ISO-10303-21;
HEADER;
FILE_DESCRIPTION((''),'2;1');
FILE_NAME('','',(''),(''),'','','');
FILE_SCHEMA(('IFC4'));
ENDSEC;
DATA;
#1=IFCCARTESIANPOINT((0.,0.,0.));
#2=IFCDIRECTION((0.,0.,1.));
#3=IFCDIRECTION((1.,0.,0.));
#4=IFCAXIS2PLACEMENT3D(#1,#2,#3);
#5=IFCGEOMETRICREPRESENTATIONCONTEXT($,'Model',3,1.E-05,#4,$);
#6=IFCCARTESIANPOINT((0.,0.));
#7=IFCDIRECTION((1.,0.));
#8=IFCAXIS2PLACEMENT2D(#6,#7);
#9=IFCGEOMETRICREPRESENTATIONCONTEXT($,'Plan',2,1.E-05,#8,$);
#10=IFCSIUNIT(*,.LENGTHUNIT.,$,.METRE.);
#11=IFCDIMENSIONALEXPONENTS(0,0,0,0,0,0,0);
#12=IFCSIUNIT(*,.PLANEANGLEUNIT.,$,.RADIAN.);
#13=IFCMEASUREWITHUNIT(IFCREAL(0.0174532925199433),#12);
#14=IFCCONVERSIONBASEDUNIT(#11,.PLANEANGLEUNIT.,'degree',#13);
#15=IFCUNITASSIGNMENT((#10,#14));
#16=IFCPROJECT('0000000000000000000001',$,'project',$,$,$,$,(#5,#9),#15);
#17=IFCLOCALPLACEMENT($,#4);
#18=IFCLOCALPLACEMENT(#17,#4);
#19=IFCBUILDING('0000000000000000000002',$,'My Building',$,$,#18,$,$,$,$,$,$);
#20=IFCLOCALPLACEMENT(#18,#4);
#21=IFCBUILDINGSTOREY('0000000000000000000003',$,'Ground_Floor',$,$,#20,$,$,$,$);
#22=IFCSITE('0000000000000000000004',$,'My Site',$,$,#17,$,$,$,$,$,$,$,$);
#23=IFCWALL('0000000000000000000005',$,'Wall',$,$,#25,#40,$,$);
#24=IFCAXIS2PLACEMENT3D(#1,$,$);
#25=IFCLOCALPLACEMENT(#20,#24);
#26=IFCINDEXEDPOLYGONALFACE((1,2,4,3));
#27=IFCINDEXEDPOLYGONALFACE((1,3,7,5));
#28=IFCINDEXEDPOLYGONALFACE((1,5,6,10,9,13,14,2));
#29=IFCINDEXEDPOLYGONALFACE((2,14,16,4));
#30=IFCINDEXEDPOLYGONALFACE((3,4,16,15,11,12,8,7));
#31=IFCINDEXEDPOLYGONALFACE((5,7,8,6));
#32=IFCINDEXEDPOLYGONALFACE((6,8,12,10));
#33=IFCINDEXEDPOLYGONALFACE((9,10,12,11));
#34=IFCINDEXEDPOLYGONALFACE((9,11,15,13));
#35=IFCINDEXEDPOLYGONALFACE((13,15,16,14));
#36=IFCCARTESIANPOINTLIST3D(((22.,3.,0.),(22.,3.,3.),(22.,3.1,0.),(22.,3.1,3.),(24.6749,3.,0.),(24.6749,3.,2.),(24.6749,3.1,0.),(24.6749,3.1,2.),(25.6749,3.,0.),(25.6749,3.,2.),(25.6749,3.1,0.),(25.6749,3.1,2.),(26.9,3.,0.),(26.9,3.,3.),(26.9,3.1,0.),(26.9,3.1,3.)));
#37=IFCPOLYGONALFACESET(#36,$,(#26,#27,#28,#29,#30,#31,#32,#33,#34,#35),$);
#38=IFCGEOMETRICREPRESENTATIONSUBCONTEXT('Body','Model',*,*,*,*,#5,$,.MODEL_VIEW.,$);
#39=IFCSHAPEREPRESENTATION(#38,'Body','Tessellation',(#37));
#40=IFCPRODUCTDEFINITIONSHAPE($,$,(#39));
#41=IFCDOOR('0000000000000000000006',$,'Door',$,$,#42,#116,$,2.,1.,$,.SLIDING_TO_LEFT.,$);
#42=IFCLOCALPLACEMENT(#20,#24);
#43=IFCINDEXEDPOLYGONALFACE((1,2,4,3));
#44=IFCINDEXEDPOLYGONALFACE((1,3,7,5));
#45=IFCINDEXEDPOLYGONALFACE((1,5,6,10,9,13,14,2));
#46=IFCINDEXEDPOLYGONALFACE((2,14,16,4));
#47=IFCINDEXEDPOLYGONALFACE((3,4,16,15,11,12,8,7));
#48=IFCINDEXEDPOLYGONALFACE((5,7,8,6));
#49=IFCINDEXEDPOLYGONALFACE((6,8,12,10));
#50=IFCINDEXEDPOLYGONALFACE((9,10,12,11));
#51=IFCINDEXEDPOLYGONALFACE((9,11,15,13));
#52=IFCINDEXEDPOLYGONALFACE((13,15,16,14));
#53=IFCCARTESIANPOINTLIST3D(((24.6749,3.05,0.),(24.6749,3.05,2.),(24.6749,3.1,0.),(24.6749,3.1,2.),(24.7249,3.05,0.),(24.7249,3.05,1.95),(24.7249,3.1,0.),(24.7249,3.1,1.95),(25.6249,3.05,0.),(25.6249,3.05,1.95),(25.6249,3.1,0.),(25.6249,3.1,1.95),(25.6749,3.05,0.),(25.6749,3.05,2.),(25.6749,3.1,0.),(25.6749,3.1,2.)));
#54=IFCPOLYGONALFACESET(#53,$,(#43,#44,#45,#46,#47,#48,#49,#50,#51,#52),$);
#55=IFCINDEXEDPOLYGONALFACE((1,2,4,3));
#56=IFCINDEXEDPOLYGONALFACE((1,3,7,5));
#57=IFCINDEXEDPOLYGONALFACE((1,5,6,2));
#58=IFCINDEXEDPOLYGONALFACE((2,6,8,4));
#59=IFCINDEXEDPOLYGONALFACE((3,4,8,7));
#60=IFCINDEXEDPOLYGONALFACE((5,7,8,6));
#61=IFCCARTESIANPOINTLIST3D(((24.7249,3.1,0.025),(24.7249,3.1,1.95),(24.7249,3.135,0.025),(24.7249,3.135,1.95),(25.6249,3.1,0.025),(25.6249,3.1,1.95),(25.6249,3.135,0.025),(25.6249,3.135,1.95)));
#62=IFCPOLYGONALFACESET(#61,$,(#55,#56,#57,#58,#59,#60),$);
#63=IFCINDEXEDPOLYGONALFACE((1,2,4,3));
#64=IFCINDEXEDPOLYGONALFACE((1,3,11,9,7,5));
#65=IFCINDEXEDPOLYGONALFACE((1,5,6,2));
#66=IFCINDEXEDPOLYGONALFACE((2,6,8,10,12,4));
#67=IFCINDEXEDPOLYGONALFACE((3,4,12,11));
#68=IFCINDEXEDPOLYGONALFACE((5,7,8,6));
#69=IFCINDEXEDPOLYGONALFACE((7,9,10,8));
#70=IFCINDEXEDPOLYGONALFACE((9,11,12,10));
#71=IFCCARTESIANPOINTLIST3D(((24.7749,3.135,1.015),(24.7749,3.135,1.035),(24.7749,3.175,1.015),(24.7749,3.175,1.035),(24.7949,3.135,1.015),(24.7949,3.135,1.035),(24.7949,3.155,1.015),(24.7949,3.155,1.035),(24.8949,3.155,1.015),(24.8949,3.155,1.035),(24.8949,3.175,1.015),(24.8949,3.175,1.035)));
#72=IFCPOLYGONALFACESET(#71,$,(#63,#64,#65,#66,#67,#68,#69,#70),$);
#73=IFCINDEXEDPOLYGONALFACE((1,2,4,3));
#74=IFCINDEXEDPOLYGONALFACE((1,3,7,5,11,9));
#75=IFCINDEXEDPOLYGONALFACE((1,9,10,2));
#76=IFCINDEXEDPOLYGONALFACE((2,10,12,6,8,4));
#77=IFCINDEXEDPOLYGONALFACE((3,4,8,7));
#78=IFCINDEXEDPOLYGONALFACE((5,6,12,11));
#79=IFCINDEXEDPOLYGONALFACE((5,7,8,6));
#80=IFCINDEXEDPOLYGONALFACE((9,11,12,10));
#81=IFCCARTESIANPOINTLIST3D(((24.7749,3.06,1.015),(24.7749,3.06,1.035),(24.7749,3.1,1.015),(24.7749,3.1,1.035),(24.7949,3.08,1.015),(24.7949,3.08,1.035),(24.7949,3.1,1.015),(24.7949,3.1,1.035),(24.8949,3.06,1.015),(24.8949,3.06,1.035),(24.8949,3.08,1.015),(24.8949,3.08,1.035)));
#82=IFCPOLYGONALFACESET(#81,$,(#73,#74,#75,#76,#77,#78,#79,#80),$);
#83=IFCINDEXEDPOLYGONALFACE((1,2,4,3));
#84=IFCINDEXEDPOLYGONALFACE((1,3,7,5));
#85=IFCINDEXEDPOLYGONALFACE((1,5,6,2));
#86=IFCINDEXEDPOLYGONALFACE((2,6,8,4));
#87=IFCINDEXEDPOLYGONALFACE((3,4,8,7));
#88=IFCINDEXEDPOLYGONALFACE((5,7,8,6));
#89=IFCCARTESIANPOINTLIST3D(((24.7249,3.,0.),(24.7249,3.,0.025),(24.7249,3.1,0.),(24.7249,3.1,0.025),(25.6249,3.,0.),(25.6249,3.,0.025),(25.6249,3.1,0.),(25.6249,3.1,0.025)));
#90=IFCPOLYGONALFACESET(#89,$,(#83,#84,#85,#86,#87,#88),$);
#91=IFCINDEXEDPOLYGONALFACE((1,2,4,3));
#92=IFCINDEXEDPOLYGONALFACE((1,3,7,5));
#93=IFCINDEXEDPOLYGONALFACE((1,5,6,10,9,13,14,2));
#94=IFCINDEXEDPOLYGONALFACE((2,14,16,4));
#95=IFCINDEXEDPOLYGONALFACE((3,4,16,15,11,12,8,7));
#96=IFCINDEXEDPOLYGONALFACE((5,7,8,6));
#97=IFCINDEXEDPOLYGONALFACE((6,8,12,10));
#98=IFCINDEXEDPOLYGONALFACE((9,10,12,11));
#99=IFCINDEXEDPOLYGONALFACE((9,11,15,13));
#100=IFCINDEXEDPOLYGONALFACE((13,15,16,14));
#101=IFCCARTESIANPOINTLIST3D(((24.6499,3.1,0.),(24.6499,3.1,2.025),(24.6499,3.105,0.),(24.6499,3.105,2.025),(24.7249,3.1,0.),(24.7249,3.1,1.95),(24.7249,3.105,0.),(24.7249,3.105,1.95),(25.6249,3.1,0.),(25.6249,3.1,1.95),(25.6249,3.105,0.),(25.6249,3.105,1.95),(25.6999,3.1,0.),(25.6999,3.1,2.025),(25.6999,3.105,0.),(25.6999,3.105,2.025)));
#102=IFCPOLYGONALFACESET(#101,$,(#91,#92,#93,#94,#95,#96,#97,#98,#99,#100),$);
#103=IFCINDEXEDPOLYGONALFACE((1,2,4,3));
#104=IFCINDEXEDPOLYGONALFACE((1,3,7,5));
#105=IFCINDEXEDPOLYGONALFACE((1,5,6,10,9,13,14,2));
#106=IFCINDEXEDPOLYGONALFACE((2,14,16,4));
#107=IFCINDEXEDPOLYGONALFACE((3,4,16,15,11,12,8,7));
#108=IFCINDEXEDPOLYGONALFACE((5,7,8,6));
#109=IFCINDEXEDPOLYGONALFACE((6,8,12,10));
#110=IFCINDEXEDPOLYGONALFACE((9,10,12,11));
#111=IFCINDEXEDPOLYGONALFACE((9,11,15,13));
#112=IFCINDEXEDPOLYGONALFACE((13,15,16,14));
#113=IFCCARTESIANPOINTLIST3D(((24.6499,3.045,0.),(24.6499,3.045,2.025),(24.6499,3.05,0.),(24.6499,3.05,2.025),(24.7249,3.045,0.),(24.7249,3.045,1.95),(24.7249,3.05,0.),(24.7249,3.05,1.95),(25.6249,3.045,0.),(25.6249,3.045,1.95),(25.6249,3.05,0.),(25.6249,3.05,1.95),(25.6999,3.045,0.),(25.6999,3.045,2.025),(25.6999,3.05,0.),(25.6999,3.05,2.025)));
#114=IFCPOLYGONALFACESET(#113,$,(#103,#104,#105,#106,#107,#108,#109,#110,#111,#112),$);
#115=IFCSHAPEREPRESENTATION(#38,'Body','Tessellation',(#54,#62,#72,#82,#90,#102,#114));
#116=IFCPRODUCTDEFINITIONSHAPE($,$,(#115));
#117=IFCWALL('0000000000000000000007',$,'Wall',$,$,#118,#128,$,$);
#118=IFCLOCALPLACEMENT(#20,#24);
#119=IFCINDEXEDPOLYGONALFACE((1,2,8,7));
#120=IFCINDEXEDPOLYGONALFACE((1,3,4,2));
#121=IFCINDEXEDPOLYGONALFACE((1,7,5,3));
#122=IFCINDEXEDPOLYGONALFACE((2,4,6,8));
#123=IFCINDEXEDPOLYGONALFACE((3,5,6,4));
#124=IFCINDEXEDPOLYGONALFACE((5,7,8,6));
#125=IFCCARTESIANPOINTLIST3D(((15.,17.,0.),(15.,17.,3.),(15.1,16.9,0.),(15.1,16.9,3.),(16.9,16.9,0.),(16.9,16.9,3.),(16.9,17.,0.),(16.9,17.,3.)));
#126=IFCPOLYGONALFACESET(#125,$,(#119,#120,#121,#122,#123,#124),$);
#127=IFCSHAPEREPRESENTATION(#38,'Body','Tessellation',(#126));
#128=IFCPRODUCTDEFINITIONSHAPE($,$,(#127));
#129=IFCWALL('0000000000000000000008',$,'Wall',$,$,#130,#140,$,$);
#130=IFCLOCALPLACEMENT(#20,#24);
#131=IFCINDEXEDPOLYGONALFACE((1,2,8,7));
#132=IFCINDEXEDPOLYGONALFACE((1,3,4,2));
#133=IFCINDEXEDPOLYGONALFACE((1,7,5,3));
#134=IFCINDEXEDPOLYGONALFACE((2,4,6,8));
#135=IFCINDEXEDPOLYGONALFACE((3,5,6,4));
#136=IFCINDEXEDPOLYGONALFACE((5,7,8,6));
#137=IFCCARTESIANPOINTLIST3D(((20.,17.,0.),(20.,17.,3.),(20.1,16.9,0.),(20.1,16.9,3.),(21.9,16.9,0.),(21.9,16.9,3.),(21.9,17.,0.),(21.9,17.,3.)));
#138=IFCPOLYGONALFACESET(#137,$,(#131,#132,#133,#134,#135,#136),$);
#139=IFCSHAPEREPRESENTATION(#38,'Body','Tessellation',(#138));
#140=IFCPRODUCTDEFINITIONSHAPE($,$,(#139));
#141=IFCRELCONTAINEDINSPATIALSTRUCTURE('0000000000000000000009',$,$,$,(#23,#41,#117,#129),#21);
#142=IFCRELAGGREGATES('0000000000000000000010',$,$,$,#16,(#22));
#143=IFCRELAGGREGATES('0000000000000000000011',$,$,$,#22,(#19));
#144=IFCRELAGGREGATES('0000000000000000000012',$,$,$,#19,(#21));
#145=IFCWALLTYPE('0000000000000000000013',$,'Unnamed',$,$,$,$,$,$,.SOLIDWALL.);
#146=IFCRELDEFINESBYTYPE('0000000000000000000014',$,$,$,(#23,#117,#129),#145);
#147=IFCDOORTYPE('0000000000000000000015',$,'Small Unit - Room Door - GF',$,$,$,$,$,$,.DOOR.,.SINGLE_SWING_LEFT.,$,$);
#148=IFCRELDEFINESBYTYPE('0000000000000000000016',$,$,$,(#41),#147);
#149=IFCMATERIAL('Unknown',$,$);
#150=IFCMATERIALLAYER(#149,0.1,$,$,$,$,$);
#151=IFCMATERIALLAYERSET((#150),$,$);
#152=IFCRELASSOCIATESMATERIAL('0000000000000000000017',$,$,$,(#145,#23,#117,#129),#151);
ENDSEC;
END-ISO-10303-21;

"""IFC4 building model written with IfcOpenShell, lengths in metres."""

from ifc_helpers import new_model, entity, si_unit, converted_unit, frame, origin_with_axes, origin_2d_with_axis, place, context, subcontext, project, spatial, line, indexed_curve, outline, extrude, shape, source, transform, mapped, material, layer, layer_set, layer_usage, type_object, type_shapes, element, fill, save


model = new_model("IFC4")

# Units and contexts
model_context = context("Model", 3, precision=1e-05, world=origin_with_axes())
plan_context = context("Plan", 2, precision=1e-05, world=origin_2d_with_axis())
body_context_1 = subcontext(model_context, "Body", "Model", "MODEL_VIEW")
body_context_2 = subcontext(plan_context, "Body", "Plan", "PLAN_VIEW")
ifc_project = project(units=[si_unit("LENGTHUNIT", "METRE"), converted_unit("PLANEANGLEUNIT", "degree", entity("IfcReal", 0.0174532925199433), si_unit("PLANEANGLEUNIT", "RADIAN"), dimensions=[0, 0, 0, 0, 0, 0, 0])], contexts=[model_context, plan_context])

# Site, building, storey
site_placement = place(None, origin_with_axes())
site = spatial("IfcSite", under=ifc_project, at=site_placement, Name="My Site")
building_placement = place(site_placement, origin_with_axes())
building = spatial("IfcBuilding", under=site, at=building_placement, Name="My Building")
storey_placement = place(building_placement, origin_with_axes())
storey = spatial("IfcBuildingStorey", under=building, at=storey_placement, Name="Ground_Floor")

# Shared definitions
ifc_material = material(Name="Unknown")
ifc_layer = layer(ifc_material, 0.1)
ifc_layer_set = layer_set([ifc_layer])
wall_type = type_object("IfcWallType", Name="Unnamed", PredefinedType="SOLIDWALL", material=ifc_layer_set)

# Shared definitions
shared_shape_1 = source(origin_with_axes(), body_context_1, "Body", "SweptSolid", [
    extrude(outline(indexed_curve([(0.0, 0.0), (1.0, 0.0), (1.0, 2.0), (0.0, 2.0)], segments=[line(1, 2, 3, 4, 1)])), frame((0.0, -0.6, 0.0), z_axis=(0.0, -1.0, 0.0), x_axis=(1.0, 0.0, 0.0)), (0.0, 0.0, -1.0), 1.2),
])
door_type_1 = type_object("IfcDoorType", Name="Small Unit - Room Door - GF", OperationType="SINGLE_SWING_LEFT", PredefinedType="DOOR")
shared_shape_2 = source(origin_with_axes(), body_context_1, "Body", "SweptSolid", [
    extrude(outline(indexed_curve([(0.0, 0.0), (0.0, 2.0), (1.0, 2.0), (1.0, 0.0), (0.95, 0.0), (0.95, 1.95), (0.05, 1.95), (0.05, 0.0)], segments=[line(1, 2, 3, 4, 5, 6, 7, 8, 1)])), frame((0.0, 0.0, 0.0), z_axis=(0.0, -1.0, 0.0), x_axis=(1.0, 0.0, 0.0)), (0.0, 0.0, -1.0), 0.05),
    extrude(outline(indexed_curve([(0.0, 0.0), (0.9, 0.0), (0.9, 0.035), (0.0, 0.035)], segments=[line(1, 2, 3, 4, 1)])), frame((0.05, -0.035, 0.025), z_axis=(0.0, 0.0, 1.0), x_axis=(1.0, 0.0, 0.0)), (0.0, 0.0, 1.0), 1.925),
    extrude(outline(indexed_curve([(0.0, 0.0), (0.0, -0.04), (-0.12, -0.04), (-0.12, -0.02), (-0.02, -0.02), (-0.02, 0.0)], segments=[line(1, 2, 3, 4, 5, 6, 1)])), frame((0.9, -0.035, 1.015), z_axis=(0.0, 0.0, 1.0), x_axis=(1.0, 0.0, 0.0)), (0.0, 0.0, 1.0), 0.02),
    extrude(outline(indexed_curve([(0.0, 0.0), (0.0, 0.04), (-0.12, 0.04), (-0.12, 0.02), (-0.02, 0.02), (-0.02, 0.0)], segments=[line(1, 2, 3, 4, 5, 6, 1)])), frame((0.9, 0.0, 1.015), z_axis=(0.0, 0.0, 1.0), x_axis=(1.0, 0.0, 0.0)), (0.0, 0.0, 1.0), 0.02),
    extrude(outline(indexed_curve([(0.0, 0.0), (0.9, 0.0), (0.9, 0.1), (0.0, 0.1)], segments=[line(1, 2, 3, 4, 1)])), frame((0.05, 0.0, 0.0), z_axis=(0.0, 0.0, 1.0), x_axis=(1.0, 0.0, 0.0)), (0.0, 0.0, 1.0), 0.025),
    extrude(outline(indexed_curve([(0.0, 0.0), (0.0, 2.025), (1.05, 2.025), (1.05, 0.0), (0.975, 0.0), (0.975, 1.95), (0.075, 1.95), (0.075, 0.0)], segments=[line(1, 2, 3, 4, 5, 6, 7, 8, 1)])), frame((-0.025, -0.005, 0.0), z_axis=(0.0, -1.0, 0.0), x_axis=(1.0, 0.0, 0.0)), (0.0, 0.0, -1.0), 0.005),
    extrude(outline(indexed_curve([(0.0, 0.0), (0.0, 2.025), (1.05, 2.025), (1.05, 0.0), (0.975, 0.0), (0.975, 1.95), (0.075, 1.95), (0.075, 0.0)], segments=[line(1, 2, 3, 4, 5, 6, 7, 8, 1)])), frame((-0.025, 0.05, 0.0), z_axis=(0.0, -1.0, 0.0), x_axis=(1.0, 0.0, 0.0)), (0.0, 0.0, -1.0), 0.005),
])
shared_shape_3 = source(origin_with_axes(), body_context_2, "Body", "Curve2D", [
    entity("IfcIndexedPolyCurve", entity("IfcCartesianPointList2D", [[0.0, 0.0], [0.05, 0.0], [0.05, 0.05], [0.0, 0.05]]), [entity("IfcLineIndex", [1, 2, 3, 4, 1])]),
    entity("IfcIndexedPolyCurve", entity("IfcCartesianPointList2D", [[1.0, 0.0], [0.95, 0.0], [0.95, 0.05], [1.0, 0.05]]), [entity("IfcLineIndex", [1, 2, 3, 4, 1])]),
    entity("IfcIndexedPolyCurve", entity("IfcCartesianPointList2D", [[-0.4, -0.035], [0.5, -0.035], [0.5, 0.0], [-0.4, 0.0]]), [entity("IfcLineIndex", [1, 2, 3, 4, 1])]),
])
type_shapes(door_type_1, [shared_shape_2, shared_shape_3])

# Wall, opening, door
ifc_layer_usage_1 = layer_usage(ifc_layer_set, "AXIS2", "POSITIVE", 0.0)
wall_1_placement = place(storey_placement, frame((22.0, 3.0, 0.0), z_axis=(0.0, 0.0, 1.0), x_axis=(1.0, 0.0, 0.0)))
wall_1 = element("IfcWall", 1, at=wall_1_placement, inside=storey, type_object=wall_type, material=ifc_layer_usage_1, Name="Wall", context=body_context_1, shape_type="SweptSolid", body=[
    extrude(outline(indexed_curve([(0.0, 0.0), (0.0, 0.1), (4.9, 0.1), (4.9, 0.0)], segments=[line(1, 2, 3, 4, 1)])), origin_with_axes(), (0.0, 0.0, 1.0), 3.0),
])
opening_1_placement = place(wall_1_placement, frame((3.6749, 0.1, 0.0), z_axis=(0.0, 0.0, 1.0), x_axis=(-1.0, 0.0, 0.0)))
opening_1 = element("IfcOpeningElement", 2, at=opening_1_placement, cuts=wall_1, PredefinedType="OPENING", context=body_context_1, shape_type="MappedRepresentation", body=[
    mapped(shared_shape_1, transform((0.0, 0.0, 0.0), x_axis=(1.0, 0.0, 0.0), y_axis=(0.0, 1.0, 0.0), z_axis=(0.0, 0.0, 1.0), scale=1.0)),
])
door_1_placement = place(opening_1_placement, origin_with_axes())
door_1 = element("IfcDoor", 3, at=door_1_placement, inside=storey, type_object=door_type_1, Name="Door", OperationType="SLIDING_TO_LEFT", OverallHeight=2.0, OverallWidth=1.0, shapes=[
    shape(body_context_1, "Body", "MappedRepresentation", [mapped(shared_shape_2, transform((0.0, 0.0, 0.0), x_axis=(1.0, 0.0, 0.0), y_axis=(0.0, 1.0, 0.0), z_axis=(0.0, 0.0, 1.0), scale=1.0))]),
    shape(body_context_2, "Body", "MappedRepresentation", [mapped(shared_shape_3, transform((0.0, 0.0, 0.0), x_axis=(1.0, 0.0, 0.0), y_axis=(0.0, 1.0, 0.0), z_axis=(0.0, 0.0, 1.0), scale=1.0))]),
])
fill(opening_1, door_1)

# Walls
ifc_layer_usage_2 = layer_usage(ifc_layer_set, "AXIS2", "POSITIVE", 0.0)
wall_2_placement = place(storey_placement, frame((17.0, 17.0, 0.0), z_axis=(0.0, 0.0, 1.0), x_axis=(-1.0, 0.0, 0.0)))
element("IfcWall", 4, at=wall_2_placement, inside=storey, type_object=wall_type, material=ifc_layer_usage_2, Name="Wall", context=body_context_1, shape_type="SweptSolid", body=[
    extrude(outline(indexed_curve([(0.1, 0.0), (0.1, 0.1), (1.9, 0.1), (2.0, 0.0)], segments=[line(1, 2, 3, 4, 1)])), origin_with_axes(), (0.0, 0.0, 1.0), 3.0),
])
ifc_layer_usage_3 = layer_usage(ifc_layer_set, "AXIS2", "POSITIVE", 0.0)
wall_3_placement = place(storey_placement, frame((22.0, 17.0, 0.0), z_axis=(0.0, 0.0, 1.0), x_axis=(-1.0, 0.0, 0.0)))
element("IfcWall", 5, at=wall_3_placement, inside=storey, type_object=wall_type, material=ifc_layer_usage_3, Name="Wall", context=body_context_1, shape_type="SweptSolid", body=[
    extrude(outline(indexed_curve([(0.1, 0.0), (0.1, 0.1), (1.9, 0.1), (2.0, 0.0)], segments=[line(1, 2, 3, 4, 1)])), origin_with_axes(), (0.0, 0.0, 1.0), 3.0),
])

save(model, "model.ifc")
